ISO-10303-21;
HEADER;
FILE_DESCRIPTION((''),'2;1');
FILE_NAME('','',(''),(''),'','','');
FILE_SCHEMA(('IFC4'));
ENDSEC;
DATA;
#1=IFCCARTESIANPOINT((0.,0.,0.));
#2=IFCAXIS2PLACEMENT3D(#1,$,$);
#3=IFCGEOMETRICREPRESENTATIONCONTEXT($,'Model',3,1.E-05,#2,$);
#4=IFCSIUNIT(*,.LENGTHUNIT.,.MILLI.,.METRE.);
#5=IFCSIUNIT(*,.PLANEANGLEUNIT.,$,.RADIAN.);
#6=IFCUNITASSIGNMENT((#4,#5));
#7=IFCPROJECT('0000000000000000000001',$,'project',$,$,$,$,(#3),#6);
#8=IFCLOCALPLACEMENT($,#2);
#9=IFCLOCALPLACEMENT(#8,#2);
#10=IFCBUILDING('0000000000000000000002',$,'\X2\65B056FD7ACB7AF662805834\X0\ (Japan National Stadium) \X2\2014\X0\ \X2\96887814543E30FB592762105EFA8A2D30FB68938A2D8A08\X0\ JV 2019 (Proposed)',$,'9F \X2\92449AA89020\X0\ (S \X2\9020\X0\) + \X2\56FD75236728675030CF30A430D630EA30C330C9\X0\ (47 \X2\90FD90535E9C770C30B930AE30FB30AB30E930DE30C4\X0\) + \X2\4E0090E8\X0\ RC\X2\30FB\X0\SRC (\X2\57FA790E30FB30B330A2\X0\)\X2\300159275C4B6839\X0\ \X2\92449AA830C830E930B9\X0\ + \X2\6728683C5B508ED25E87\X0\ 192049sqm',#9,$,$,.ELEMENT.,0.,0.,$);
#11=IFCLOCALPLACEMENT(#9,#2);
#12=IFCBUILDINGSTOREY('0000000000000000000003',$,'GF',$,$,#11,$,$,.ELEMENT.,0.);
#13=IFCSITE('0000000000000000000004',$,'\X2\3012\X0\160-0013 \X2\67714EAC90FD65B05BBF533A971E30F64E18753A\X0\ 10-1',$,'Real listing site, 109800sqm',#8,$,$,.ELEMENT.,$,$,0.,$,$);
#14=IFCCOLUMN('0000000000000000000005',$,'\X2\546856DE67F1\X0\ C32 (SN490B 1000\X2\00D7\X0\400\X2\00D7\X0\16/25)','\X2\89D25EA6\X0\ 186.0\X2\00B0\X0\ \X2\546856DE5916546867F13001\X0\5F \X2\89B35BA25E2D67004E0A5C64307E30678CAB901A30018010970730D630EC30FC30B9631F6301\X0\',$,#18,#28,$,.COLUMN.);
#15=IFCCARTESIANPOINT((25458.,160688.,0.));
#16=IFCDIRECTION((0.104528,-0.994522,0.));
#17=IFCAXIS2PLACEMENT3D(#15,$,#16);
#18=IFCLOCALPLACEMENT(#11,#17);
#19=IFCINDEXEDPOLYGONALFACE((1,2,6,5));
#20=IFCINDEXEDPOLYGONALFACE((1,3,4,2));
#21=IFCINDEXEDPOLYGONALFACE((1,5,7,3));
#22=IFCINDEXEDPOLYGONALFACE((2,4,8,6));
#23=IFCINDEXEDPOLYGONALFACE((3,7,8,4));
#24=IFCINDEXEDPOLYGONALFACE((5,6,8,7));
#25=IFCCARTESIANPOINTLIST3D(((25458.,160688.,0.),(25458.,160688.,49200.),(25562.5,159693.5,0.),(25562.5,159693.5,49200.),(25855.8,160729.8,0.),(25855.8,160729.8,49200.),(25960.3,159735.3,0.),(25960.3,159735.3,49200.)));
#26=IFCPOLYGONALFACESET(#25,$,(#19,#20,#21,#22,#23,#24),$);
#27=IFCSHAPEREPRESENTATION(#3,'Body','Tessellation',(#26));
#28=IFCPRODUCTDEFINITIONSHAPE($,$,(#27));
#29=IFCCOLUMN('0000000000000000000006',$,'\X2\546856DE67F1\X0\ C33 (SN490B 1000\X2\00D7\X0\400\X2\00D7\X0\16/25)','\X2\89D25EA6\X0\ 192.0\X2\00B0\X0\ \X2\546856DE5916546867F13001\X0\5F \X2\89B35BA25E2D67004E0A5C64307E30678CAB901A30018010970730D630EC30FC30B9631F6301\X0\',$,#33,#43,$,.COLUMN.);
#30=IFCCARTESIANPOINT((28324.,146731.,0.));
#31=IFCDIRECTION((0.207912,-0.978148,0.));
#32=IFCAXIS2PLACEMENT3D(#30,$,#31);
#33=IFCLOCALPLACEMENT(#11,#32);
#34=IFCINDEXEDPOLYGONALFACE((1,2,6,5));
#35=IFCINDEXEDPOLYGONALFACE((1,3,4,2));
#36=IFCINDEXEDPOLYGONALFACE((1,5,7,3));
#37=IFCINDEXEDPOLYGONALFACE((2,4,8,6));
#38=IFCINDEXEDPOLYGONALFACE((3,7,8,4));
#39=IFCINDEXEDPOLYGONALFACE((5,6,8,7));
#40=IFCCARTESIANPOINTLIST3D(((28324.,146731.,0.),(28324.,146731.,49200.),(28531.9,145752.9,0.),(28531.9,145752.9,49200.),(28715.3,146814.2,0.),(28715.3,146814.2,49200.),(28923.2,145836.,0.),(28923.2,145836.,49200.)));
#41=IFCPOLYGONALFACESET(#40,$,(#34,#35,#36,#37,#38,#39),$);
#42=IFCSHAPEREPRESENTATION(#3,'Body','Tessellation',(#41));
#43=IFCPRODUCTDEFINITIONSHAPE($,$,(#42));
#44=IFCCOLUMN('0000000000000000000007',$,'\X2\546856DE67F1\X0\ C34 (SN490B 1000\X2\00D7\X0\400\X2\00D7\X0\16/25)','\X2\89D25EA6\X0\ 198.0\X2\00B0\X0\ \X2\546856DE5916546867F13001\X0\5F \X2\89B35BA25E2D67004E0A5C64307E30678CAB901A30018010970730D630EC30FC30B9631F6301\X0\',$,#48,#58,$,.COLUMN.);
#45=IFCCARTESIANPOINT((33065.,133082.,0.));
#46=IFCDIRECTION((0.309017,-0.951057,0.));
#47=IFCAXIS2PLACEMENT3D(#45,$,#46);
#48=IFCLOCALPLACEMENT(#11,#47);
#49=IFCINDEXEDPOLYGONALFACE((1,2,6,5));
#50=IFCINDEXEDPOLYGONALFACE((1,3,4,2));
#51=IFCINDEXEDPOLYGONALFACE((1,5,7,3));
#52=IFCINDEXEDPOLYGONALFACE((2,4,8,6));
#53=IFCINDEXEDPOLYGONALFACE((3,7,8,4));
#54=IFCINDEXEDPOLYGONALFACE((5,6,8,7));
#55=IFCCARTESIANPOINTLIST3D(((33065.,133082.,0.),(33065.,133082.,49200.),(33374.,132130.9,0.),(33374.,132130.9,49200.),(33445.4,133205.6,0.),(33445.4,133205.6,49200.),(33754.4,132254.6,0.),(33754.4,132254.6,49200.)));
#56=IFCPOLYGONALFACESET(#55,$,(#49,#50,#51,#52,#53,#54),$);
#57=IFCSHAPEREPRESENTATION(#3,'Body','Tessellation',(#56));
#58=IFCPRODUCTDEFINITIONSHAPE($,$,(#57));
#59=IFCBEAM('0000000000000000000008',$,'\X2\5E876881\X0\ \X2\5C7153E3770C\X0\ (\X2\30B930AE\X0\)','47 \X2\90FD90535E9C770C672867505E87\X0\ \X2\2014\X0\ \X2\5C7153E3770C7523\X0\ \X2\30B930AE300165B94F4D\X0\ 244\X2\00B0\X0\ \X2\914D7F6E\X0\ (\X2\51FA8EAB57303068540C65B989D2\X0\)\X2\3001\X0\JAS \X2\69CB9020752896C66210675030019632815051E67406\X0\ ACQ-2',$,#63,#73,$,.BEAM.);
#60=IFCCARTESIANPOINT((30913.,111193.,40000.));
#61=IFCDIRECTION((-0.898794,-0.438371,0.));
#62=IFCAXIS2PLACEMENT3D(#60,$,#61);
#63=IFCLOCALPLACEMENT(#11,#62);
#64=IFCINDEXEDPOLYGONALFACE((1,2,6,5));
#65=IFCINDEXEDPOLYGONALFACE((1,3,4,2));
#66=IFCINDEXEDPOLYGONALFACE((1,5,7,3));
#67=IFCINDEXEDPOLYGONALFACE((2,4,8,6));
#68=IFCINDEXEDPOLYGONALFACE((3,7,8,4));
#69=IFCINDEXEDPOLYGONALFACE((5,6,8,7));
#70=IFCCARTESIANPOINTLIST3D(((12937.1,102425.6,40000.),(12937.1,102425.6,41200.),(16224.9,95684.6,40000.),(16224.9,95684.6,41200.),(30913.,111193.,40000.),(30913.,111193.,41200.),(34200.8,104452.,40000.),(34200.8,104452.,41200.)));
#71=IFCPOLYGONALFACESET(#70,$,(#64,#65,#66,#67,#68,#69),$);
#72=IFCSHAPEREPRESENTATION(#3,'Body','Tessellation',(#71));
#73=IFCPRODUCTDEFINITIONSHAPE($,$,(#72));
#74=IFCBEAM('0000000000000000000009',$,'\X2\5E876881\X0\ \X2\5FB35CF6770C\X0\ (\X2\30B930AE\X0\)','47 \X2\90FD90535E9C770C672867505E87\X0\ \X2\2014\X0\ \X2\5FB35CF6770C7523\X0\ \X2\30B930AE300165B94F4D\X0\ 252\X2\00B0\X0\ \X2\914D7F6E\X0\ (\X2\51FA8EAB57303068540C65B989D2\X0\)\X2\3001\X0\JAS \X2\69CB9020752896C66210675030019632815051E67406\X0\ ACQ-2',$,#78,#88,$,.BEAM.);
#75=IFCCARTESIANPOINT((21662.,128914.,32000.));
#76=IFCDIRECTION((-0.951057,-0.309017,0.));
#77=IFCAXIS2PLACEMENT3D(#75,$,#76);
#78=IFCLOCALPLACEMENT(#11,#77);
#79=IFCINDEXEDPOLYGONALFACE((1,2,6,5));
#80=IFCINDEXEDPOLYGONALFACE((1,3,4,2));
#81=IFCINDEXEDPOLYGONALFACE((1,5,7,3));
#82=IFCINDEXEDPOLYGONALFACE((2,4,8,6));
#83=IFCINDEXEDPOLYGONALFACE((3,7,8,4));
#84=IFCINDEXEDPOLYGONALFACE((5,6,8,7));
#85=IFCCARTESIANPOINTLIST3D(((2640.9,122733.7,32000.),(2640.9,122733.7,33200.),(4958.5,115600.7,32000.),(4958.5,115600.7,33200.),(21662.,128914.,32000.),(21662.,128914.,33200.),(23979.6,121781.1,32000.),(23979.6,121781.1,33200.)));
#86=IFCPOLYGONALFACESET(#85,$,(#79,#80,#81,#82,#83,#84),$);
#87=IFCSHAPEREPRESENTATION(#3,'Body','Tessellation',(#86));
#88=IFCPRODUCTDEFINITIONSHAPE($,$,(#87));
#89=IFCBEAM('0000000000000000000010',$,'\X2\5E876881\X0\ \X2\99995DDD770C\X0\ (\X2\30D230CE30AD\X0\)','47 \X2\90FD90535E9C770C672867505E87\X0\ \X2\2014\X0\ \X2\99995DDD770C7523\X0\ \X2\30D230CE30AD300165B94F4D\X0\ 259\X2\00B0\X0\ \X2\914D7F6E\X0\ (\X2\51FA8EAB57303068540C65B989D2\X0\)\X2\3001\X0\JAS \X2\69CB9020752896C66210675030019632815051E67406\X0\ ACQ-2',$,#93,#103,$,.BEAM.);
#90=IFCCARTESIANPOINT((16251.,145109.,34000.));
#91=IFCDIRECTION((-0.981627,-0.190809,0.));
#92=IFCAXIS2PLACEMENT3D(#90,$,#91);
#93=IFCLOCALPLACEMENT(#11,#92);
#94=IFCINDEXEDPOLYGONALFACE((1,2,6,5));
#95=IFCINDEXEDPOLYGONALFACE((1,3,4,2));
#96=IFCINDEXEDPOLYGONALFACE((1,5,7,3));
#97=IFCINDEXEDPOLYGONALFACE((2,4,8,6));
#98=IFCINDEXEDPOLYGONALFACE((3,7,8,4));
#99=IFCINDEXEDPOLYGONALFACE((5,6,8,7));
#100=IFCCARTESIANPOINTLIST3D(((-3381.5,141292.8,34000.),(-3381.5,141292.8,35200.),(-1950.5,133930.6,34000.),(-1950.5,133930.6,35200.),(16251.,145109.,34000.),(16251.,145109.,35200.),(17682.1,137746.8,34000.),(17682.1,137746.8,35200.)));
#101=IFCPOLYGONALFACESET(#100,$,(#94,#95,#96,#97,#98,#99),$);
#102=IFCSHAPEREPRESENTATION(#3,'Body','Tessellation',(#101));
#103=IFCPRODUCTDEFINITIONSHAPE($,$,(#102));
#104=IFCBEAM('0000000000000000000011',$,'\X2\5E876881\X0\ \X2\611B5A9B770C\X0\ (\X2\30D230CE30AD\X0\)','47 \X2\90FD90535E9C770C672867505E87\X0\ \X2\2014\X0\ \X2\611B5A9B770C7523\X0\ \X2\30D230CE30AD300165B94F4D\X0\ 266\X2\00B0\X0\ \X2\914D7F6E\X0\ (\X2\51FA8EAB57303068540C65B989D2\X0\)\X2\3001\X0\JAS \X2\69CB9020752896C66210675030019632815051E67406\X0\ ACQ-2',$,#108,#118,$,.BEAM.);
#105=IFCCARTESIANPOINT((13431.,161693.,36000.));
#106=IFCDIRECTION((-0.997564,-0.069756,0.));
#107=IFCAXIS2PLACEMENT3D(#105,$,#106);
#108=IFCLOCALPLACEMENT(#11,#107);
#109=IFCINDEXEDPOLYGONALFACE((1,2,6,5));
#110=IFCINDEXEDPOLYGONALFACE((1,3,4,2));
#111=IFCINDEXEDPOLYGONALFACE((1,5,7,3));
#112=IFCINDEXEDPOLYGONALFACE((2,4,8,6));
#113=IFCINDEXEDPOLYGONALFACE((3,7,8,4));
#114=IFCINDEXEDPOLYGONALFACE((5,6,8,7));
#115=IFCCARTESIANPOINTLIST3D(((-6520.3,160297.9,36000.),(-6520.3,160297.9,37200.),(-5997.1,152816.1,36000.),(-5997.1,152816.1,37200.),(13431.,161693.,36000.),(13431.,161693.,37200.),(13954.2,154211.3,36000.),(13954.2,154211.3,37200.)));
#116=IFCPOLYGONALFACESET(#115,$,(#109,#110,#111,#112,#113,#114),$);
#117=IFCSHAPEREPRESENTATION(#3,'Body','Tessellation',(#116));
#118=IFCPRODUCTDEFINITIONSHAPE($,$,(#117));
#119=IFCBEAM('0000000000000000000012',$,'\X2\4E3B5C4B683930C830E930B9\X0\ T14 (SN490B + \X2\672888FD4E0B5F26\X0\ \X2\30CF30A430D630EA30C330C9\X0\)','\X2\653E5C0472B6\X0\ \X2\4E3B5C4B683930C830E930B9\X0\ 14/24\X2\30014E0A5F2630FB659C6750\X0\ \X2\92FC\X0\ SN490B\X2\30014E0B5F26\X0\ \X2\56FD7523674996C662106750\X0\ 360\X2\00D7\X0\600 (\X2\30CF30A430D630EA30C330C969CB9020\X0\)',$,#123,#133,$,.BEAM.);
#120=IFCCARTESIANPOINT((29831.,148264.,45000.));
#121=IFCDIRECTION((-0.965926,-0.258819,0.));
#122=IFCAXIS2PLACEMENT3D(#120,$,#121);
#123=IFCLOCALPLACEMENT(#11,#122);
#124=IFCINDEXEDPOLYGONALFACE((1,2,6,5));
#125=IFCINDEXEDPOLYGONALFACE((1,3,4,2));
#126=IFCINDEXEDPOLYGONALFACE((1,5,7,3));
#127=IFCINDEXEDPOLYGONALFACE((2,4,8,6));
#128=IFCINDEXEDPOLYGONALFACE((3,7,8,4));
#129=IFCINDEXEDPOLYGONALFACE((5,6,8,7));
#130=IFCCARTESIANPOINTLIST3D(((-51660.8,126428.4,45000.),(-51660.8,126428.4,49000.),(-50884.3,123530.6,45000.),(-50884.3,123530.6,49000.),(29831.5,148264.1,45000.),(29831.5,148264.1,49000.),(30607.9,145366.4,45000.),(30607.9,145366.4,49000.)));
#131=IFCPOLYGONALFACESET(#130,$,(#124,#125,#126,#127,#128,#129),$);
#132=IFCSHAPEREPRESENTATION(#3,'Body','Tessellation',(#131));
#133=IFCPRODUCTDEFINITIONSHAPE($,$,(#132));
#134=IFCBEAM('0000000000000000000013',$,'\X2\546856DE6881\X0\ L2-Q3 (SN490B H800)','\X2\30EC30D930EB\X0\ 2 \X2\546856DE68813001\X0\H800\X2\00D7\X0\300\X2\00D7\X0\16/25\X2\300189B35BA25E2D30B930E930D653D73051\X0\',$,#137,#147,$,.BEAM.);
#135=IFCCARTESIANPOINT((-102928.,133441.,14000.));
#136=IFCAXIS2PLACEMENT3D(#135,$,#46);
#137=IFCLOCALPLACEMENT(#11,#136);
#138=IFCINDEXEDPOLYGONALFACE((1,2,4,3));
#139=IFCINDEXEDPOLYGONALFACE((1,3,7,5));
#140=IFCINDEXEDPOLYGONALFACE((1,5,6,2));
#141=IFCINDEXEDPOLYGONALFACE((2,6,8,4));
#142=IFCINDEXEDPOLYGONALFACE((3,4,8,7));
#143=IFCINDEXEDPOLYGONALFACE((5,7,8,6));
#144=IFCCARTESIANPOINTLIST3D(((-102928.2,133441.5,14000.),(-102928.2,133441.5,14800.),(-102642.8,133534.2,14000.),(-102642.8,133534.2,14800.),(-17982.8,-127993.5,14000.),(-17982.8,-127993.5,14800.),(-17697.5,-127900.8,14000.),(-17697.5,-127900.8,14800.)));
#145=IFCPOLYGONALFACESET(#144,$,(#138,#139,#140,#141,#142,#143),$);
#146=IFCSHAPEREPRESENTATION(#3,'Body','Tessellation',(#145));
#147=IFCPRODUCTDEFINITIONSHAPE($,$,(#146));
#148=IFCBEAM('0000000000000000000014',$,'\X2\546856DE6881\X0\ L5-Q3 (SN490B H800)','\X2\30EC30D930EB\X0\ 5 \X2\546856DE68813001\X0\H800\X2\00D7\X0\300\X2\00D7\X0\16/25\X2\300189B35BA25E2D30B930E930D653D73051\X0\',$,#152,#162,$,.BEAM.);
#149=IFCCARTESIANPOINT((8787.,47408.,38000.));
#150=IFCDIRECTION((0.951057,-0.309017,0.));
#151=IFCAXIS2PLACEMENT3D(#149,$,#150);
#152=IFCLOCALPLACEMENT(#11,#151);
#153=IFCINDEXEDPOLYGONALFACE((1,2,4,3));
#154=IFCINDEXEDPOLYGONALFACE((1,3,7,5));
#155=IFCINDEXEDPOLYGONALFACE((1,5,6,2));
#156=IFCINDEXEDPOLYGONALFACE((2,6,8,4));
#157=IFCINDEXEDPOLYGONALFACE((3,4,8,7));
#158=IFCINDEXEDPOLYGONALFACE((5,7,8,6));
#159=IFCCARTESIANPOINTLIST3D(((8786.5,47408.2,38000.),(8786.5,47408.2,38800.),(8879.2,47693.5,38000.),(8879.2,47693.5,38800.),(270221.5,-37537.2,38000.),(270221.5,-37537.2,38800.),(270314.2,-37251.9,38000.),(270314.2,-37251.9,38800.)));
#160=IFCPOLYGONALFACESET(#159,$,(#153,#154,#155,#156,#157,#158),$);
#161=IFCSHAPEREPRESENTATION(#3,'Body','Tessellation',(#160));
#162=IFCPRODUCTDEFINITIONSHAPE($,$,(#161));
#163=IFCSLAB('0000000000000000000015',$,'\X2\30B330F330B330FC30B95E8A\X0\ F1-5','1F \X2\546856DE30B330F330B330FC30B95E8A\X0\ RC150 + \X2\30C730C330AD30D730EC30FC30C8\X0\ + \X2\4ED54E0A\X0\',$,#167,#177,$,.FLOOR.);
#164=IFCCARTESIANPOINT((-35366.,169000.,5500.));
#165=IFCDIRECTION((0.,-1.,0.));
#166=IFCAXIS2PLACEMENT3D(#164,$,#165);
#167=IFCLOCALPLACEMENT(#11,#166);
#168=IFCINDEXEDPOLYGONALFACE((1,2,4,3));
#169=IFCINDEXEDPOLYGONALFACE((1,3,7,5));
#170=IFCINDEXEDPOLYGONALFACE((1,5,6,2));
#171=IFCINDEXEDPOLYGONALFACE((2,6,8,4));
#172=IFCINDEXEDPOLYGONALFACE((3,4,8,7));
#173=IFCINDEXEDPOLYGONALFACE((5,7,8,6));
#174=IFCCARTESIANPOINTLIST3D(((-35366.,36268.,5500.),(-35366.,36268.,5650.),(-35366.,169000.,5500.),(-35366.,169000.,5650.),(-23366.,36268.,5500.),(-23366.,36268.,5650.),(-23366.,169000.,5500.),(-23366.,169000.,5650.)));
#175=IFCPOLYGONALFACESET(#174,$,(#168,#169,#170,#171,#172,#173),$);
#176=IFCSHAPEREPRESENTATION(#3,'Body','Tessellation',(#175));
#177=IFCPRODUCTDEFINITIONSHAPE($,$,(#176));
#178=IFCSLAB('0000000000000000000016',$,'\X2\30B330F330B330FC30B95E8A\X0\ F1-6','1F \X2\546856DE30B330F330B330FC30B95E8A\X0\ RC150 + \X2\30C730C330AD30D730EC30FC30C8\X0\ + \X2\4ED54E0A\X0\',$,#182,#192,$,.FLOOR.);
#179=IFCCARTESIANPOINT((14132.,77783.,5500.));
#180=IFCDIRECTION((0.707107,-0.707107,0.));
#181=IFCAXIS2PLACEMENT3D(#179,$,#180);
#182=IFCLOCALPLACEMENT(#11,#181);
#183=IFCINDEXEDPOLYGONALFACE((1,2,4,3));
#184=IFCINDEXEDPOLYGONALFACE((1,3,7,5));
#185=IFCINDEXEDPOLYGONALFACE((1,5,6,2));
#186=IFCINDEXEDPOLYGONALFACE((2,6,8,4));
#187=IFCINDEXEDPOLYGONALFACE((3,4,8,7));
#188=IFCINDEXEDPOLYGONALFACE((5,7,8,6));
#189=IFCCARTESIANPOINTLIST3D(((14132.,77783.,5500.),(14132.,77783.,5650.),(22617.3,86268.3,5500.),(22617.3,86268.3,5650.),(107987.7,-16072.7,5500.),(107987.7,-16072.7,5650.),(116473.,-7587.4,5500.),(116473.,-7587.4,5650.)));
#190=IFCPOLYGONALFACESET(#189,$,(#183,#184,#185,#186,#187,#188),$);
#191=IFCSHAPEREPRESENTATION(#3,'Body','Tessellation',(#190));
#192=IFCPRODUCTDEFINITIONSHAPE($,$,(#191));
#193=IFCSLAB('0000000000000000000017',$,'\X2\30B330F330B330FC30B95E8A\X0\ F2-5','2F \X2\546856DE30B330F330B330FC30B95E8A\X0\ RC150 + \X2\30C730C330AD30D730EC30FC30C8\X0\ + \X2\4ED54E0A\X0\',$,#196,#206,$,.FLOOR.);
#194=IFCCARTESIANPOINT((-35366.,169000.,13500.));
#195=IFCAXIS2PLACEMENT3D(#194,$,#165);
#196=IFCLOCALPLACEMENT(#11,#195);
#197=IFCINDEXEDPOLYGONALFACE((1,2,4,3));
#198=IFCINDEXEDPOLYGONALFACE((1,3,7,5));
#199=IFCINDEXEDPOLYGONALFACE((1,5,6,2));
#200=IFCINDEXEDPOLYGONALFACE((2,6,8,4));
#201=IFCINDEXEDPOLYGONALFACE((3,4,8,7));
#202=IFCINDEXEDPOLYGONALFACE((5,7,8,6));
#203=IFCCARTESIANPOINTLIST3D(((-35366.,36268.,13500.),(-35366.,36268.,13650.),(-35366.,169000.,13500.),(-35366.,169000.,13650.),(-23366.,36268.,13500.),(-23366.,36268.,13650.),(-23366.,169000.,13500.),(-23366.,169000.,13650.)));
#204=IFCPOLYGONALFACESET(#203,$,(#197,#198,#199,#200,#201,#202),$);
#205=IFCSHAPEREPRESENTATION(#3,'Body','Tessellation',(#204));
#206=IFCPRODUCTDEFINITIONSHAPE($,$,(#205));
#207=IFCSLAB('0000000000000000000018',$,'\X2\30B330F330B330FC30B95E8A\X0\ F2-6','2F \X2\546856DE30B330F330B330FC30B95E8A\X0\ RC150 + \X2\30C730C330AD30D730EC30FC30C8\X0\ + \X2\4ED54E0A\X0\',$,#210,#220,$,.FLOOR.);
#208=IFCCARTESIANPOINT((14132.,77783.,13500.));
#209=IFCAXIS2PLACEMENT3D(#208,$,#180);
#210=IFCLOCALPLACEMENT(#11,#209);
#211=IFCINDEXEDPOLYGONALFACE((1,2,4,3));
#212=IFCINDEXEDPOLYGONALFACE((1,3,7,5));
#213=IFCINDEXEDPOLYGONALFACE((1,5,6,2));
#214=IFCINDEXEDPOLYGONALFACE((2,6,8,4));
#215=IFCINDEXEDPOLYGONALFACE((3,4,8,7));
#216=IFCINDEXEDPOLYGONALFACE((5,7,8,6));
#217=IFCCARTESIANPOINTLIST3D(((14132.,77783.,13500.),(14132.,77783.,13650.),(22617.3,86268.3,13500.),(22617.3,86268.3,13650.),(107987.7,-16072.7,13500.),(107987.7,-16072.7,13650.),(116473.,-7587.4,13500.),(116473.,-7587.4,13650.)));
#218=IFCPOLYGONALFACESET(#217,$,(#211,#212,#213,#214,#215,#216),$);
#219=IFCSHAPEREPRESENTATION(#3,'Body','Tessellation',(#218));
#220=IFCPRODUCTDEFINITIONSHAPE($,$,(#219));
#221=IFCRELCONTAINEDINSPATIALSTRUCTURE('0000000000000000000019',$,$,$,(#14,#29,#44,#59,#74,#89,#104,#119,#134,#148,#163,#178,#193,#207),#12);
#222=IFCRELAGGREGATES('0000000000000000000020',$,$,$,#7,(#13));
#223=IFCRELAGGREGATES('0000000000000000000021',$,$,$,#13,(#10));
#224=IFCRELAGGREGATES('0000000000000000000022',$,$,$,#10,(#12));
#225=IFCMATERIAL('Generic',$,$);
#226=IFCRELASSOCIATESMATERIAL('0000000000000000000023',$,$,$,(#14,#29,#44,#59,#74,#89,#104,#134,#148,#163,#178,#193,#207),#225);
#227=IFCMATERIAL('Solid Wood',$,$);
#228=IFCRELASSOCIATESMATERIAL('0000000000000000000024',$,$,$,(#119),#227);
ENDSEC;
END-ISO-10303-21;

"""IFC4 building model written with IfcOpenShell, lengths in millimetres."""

from ifc_helpers import new_model, si_unit, frame, frame_2d, origin, place, context, project, spatial, rectangle, extrude, material, element, save


model = new_model("IFC4")

# Units and contexts
model_context = context("Model", 3, precision=1e-05, world=origin())
ifc_project = project(units=[si_unit("LENGTHUNIT", "METRE", prefix="MILLI"), si_unit("PLANEANGLEUNIT", "RADIAN")], contexts=[model_context])

# Site, building, storey
site_placement = place(None, origin())
site = spatial("IfcSite", under=ifc_project, at=site_placement, Name="〒160-0013 東京都新宿区霞ヶ丘町 10-1", ObjectType="Real listing site, 109800sqm", CompositionType="ELEMENT", RefElevation=0.0)
building_placement = place(site_placement, origin())
building = spatial("IfcBuilding", under=site, at=building_placement, Name="新国立競技場 (Japan National Stadium) — 隈研吾・大成建設・梓設計 JV 2019 (Proposed)", ObjectType="9F 鉄骨造 (S 造) + 国産木材ハイブリッド (47 都道府県スギ・カラマツ) + 一部 RC・SRC (基礎・コア)、大屋根 鉄骨トラス + 木格子軒庇 192049sqm", CompositionType="ELEMENT", ElevationOfRefHeight=0.0, ElevationOfTerrain=0.0)
storey_placement = place(building_placement, origin())
storey = spatial("IfcBuildingStorey", under=building, at=storey_placement, Name="GF", CompositionType="ELEMENT", Elevation=0.0)

# Columns
ifc_material_1 = material(Name="Generic")
column_1_placement = place(storey_placement, frame((25458.0, 160688.0, 0.0), x_axis=(0.104528, -0.994522, 0.0)))
element("IfcColumn", 1, at=column_1_placement, inside=storey, material=ifc_material_1, Name="周回柱 C32 (SN490B 1000×400×16/25)", Description="角度 186.0° 周回外周柱、5F 観客席最上層まで貫通、耐震ブレース挟持", PredefinedType="COLUMN", context=model_context, shape_type="SweptSolid", body=[
    extrude(rectangle(XDim=1000.0, YDim=400.0, at=frame_2d((500.0, 200.0))), frame((25458.0, 160688.0, 0.0), x_axis=(0.104528, -0.994522, 0.0)), (0.0, 0.0, 1.0), 49200.0),
])
column_2_placement = place(storey_placement, frame((28324.0, 146731.0, 0.0), x_axis=(0.207912, -0.978148, 0.0)))
element("IfcColumn", 2, at=column_2_placement, inside=storey, material=ifc_material_1, Name="周回柱 C33 (SN490B 1000×400×16/25)", Description="角度 192.0° 周回外周柱、5F 観客席最上層まで貫通、耐震ブレース挟持", PredefinedType="COLUMN", context=model_context, shape_type="SweptSolid", body=[
    extrude(rectangle(XDim=1000.0, YDim=400.0, at=frame_2d((500.0, 200.0))), frame((28324.0, 146731.0, 0.0), x_axis=(0.207912, -0.978148, 0.0)), (0.0, 0.0, 1.0), 49200.0),
])
column_3_placement = place(storey_placement, frame((33065.0, 133082.0, 0.0), x_axis=(0.309017, -0.951057, 0.0)))
element("IfcColumn", 3, at=column_3_placement, inside=storey, material=ifc_material_1, Name="周回柱 C34 (SN490B 1000×400×16/25)", Description="角度 198.0° 周回外周柱、5F 観客席最上層まで貫通、耐震ブレース挟持", PredefinedType="COLUMN", context=model_context, shape_type="SweptSolid", body=[
    extrude(rectangle(XDim=1000.0, YDim=400.0, at=frame_2d((500.0, 200.0))), frame((33065.0, 133082.0, 0.0), x_axis=(0.309017, -0.951057, 0.0)), (0.0, 0.0, 1.0), 49200.0),
])

# Beams
beam_1_placement = place(storey_placement, frame((30913.0, 111193.0, 40000.0), x_axis=(-0.898794, -0.438371, 0.0)))
element("IfcBeam", 4, at=beam_1_placement, inside=storey, material=ifc_material_1, Name="庇梁 山口県 (スギ)", Description="47 都道府県木材庇 — 山口県産 スギ、方位 244° 配置 (出身地と同方角)、JAS 構造用集成材、防腐処理 ACQ-2", PredefinedType="BEAM", context=model_context, shape_type="SweptSolid", body=[
    extrude(rectangle(XDim=20000.0, YDim=7500.0, at=frame_2d((10000.0, 3750.0))), frame((30913.0, 111193.0, 40000.0), x_axis=(-0.898794, -0.438371, 0.0)), (0.0, 0.0, 1.0), 1200.0),
])
beam_2_placement = place(storey_placement, frame((21662.0, 128914.0, 32000.0), x_axis=(-0.951057, -0.309017, 0.0)))
element("IfcBeam", 5, at=beam_2_placement, inside=storey, material=ifc_material_1, Name="庇梁 徳島県 (スギ)", Description="47 都道府県木材庇 — 徳島県産 スギ、方位 252° 配置 (出身地と同方角)、JAS 構造用集成材、防腐処理 ACQ-2", PredefinedType="BEAM", context=model_context, shape_type="SweptSolid", body=[
    extrude(rectangle(XDim=20000.0, YDim=7500.0, at=frame_2d((10000.0, 3750.0))), frame((21662.0, 128914.0, 32000.0), x_axis=(-0.951057, -0.309017, 0.0)), (0.0, 0.0, 1.0), 1200.0),
])
beam_3_placement = place(storey_placement, frame((16251.0, 145109.0, 34000.0), x_axis=(-0.981627, -0.190809, 0.0)))
element("IfcBeam", 6, at=beam_3_placement, inside=storey, material=ifc_material_1, Name="庇梁 香川県 (ヒノキ)", Description="47 都道府県木材庇 — 香川県産 ヒノキ、方位 259° 配置 (出身地と同方角)、JAS 構造用集成材、防腐処理 ACQ-2", PredefinedType="BEAM", context=model_context, shape_type="SweptSolid", body=[
    extrude(rectangle(XDim=20000.0, YDim=7500.0, at=frame_2d((10000.0, 3750.0))), frame((16251.0, 145109.0, 34000.0), x_axis=(-0.981627, -0.190809, 0.0)), (0.0, 0.0, 1.0), 1200.0),
])
beam_4_placement = place(storey_placement, frame((13431.0, 161693.0, 36000.0), x_axis=(-0.997564, -0.069756, 0.0)))
element("IfcBeam", 7, at=beam_4_placement, inside=storey, material=ifc_material_1, Name="庇梁 愛媛県 (ヒノキ)", Description="47 都道府県木材庇 — 愛媛県産 ヒノキ、方位 266° 配置 (出身地と同方角)、JAS 構造用集成材、防腐処理 ACQ-2", PredefinedType="BEAM", context=model_context, shape_type="SweptSolid", body=[
    extrude(rectangle(XDim=20000.0, YDim=7500.0, at=frame_2d((10000.0, 3750.0))), frame((13431.0, 161693.0, 36000.0), x_axis=(-0.997564, -0.069756, 0.0)), (0.0, 0.0, 1.0), 1200.0),
])
ifc_material_2 = material(Name="Solid Wood")
beam_5_placement = place(storey_placement, frame((29831.0, 148264.0, 45000.0), x_axis=(-0.965926, -0.258819, 0.0)))
element("IfcBeam", 8, at=beam_5_placement, inside=storey, material=ifc_material_2, Name="主屋根トラス T14 (SN490B + 木製下弦 ハイブリッド)", Description="放射状 主屋根トラス 14/24、上弦・斜材 鋼 SN490B、下弦 国産杉集成材 360×600 (ハイブリッド構造)", PredefinedType="BEAM", context=model_context, shape_type="SweptSolid", body=[
    extrude(rectangle(XDim=84367.0, YDim=3000.0, at=frame_2d((42183.0, 1500.0))), frame((29831.0, 148264.0, 45000.0), x_axis=(-0.965926, -0.258819, 0.0)), (0.0, 0.0, 1.0), 4000.0),
])
beam_6_placement = place(storey_placement, frame((-102928.0, 133441.0, 14000.0), x_axis=(0.309017, -0.951057, 0.0)))
element("IfcBeam", 9, at=beam_6_placement, inside=storey, material=ifc_material_1, Name="周回梁 L2-Q3 (SN490B H800)", Description="レベル 2 周回梁、H800×300×16/25、観客席スラブ受け", PredefinedType="BEAM", context=model_context, shape_type="SweptSolid", body=[
    extrude(rectangle(XDim=274889.0, YDim=300.0, at=frame_2d((137444.0, 150.0))), frame((-102928.0, 133441.0, 14000.0), x_axis=(0.309017, -0.951057, 0.0)), (0.0, 0.0, 1.0), 800.0),
])
beam_7_placement = place(storey_placement, frame((8787.0, 47408.0, 38000.0), x_axis=(0.951057, -0.309017, 0.0)))
element("IfcBeam", 10, at=beam_7_placement, inside=storey, material=ifc_material_1, Name="周回梁 L5-Q3 (SN490B H800)", Description="レベル 5 周回梁、H800×300×16/25、観客席スラブ受け", PredefinedType="BEAM", context=model_context, shape_type="SweptSolid", body=[
    extrude(rectangle(XDim=274889.0, YDim=300.0, at=frame_2d((137444.0, 150.0))), frame((8787.0, 47408.0, 38000.0), x_axis=(0.951057, -0.309017, 0.0)), (0.0, 0.0, 1.0), 800.0),
])

# Slabs
slab_1_placement = place(storey_placement, frame((-35366.0, 169000.0, 5500.0), x_axis=(0.0, -1.0, 0.0)))
element("IfcSlab", 11, at=slab_1_placement, inside=storey, material=ifc_material_1, Name="コンコース床 F1-5", Description="1F 周回コンコース床 RC150 + デッキプレート + 仕上", PredefinedType="FLOOR", context=model_context, shape_type="SweptSolid", body=[
    extrude(rectangle(XDim=132732.0, YDim=12000.0, at=frame_2d((66366.0, 6000.0))), frame((-35366.0, 169000.0, 5500.0), x_axis=(0.0, -1.0, 0.0)), (0.0, 0.0, 1.0), 150.0),
])
slab_2_placement = place(storey_placement, frame((14132.0, 77783.0, 5500.0), x_axis=(0.707107, -0.707107, 0.0)))
element("IfcSlab", 12, at=slab_2_placement, inside=storey, material=ifc_material_1, Name="コンコース床 F1-6", Description="1F 周回コンコース床 RC150 + デッキプレート + 仕上", PredefinedType="FLOOR", context=model_context, shape_type="SweptSolid", body=[
    extrude(rectangle(XDim=132732.0, YDim=12000.0, at=frame_2d((66366.0, 6000.0))), frame((14132.0, 77783.0, 5500.0), x_axis=(0.707107, -0.707107, 0.0)), (0.0, 0.0, 1.0), 150.0),
])
slab_3_placement = place(storey_placement, frame((-35366.0, 169000.0, 13500.0), x_axis=(0.0, -1.0, 0.0)))
element("IfcSlab", 13, at=slab_3_placement, inside=storey, material=ifc_material_1, Name="コンコース床 F2-5", Description="2F 周回コンコース床 RC150 + デッキプレート + 仕上", PredefinedType="FLOOR", context=model_context, shape_type="SweptSolid", body=[
    extrude(rectangle(XDim=132732.0, YDim=12000.0, at=frame_2d((66366.0, 6000.0))), frame((-35366.0, 169000.0, 13500.0), x_axis=(0.0, -1.0, 0.0)), (0.0, 0.0, 1.0), 150.0),
])
slab_4_placement = place(storey_placement, frame((14132.0, 77783.0, 13500.0), x_axis=(0.707107, -0.707107, 0.0)))
element("IfcSlab", 14, at=slab_4_placement, inside=storey, material=ifc_material_1, Name="コンコース床 F2-6", Description="2F 周回コンコース床 RC150 + デッキプレート + 仕上", PredefinedType="FLOOR", context=model_context, shape_type="SweptSolid", body=[
    extrude(rectangle(XDim=132732.0, YDim=12000.0, at=frame_2d((66366.0, 6000.0))), frame((14132.0, 77783.0, 13500.0), x_axis=(0.707107, -0.707107, 0.0)), (0.0, 0.0, 1.0), 150.0),
])

save(model, "model.ifc")
